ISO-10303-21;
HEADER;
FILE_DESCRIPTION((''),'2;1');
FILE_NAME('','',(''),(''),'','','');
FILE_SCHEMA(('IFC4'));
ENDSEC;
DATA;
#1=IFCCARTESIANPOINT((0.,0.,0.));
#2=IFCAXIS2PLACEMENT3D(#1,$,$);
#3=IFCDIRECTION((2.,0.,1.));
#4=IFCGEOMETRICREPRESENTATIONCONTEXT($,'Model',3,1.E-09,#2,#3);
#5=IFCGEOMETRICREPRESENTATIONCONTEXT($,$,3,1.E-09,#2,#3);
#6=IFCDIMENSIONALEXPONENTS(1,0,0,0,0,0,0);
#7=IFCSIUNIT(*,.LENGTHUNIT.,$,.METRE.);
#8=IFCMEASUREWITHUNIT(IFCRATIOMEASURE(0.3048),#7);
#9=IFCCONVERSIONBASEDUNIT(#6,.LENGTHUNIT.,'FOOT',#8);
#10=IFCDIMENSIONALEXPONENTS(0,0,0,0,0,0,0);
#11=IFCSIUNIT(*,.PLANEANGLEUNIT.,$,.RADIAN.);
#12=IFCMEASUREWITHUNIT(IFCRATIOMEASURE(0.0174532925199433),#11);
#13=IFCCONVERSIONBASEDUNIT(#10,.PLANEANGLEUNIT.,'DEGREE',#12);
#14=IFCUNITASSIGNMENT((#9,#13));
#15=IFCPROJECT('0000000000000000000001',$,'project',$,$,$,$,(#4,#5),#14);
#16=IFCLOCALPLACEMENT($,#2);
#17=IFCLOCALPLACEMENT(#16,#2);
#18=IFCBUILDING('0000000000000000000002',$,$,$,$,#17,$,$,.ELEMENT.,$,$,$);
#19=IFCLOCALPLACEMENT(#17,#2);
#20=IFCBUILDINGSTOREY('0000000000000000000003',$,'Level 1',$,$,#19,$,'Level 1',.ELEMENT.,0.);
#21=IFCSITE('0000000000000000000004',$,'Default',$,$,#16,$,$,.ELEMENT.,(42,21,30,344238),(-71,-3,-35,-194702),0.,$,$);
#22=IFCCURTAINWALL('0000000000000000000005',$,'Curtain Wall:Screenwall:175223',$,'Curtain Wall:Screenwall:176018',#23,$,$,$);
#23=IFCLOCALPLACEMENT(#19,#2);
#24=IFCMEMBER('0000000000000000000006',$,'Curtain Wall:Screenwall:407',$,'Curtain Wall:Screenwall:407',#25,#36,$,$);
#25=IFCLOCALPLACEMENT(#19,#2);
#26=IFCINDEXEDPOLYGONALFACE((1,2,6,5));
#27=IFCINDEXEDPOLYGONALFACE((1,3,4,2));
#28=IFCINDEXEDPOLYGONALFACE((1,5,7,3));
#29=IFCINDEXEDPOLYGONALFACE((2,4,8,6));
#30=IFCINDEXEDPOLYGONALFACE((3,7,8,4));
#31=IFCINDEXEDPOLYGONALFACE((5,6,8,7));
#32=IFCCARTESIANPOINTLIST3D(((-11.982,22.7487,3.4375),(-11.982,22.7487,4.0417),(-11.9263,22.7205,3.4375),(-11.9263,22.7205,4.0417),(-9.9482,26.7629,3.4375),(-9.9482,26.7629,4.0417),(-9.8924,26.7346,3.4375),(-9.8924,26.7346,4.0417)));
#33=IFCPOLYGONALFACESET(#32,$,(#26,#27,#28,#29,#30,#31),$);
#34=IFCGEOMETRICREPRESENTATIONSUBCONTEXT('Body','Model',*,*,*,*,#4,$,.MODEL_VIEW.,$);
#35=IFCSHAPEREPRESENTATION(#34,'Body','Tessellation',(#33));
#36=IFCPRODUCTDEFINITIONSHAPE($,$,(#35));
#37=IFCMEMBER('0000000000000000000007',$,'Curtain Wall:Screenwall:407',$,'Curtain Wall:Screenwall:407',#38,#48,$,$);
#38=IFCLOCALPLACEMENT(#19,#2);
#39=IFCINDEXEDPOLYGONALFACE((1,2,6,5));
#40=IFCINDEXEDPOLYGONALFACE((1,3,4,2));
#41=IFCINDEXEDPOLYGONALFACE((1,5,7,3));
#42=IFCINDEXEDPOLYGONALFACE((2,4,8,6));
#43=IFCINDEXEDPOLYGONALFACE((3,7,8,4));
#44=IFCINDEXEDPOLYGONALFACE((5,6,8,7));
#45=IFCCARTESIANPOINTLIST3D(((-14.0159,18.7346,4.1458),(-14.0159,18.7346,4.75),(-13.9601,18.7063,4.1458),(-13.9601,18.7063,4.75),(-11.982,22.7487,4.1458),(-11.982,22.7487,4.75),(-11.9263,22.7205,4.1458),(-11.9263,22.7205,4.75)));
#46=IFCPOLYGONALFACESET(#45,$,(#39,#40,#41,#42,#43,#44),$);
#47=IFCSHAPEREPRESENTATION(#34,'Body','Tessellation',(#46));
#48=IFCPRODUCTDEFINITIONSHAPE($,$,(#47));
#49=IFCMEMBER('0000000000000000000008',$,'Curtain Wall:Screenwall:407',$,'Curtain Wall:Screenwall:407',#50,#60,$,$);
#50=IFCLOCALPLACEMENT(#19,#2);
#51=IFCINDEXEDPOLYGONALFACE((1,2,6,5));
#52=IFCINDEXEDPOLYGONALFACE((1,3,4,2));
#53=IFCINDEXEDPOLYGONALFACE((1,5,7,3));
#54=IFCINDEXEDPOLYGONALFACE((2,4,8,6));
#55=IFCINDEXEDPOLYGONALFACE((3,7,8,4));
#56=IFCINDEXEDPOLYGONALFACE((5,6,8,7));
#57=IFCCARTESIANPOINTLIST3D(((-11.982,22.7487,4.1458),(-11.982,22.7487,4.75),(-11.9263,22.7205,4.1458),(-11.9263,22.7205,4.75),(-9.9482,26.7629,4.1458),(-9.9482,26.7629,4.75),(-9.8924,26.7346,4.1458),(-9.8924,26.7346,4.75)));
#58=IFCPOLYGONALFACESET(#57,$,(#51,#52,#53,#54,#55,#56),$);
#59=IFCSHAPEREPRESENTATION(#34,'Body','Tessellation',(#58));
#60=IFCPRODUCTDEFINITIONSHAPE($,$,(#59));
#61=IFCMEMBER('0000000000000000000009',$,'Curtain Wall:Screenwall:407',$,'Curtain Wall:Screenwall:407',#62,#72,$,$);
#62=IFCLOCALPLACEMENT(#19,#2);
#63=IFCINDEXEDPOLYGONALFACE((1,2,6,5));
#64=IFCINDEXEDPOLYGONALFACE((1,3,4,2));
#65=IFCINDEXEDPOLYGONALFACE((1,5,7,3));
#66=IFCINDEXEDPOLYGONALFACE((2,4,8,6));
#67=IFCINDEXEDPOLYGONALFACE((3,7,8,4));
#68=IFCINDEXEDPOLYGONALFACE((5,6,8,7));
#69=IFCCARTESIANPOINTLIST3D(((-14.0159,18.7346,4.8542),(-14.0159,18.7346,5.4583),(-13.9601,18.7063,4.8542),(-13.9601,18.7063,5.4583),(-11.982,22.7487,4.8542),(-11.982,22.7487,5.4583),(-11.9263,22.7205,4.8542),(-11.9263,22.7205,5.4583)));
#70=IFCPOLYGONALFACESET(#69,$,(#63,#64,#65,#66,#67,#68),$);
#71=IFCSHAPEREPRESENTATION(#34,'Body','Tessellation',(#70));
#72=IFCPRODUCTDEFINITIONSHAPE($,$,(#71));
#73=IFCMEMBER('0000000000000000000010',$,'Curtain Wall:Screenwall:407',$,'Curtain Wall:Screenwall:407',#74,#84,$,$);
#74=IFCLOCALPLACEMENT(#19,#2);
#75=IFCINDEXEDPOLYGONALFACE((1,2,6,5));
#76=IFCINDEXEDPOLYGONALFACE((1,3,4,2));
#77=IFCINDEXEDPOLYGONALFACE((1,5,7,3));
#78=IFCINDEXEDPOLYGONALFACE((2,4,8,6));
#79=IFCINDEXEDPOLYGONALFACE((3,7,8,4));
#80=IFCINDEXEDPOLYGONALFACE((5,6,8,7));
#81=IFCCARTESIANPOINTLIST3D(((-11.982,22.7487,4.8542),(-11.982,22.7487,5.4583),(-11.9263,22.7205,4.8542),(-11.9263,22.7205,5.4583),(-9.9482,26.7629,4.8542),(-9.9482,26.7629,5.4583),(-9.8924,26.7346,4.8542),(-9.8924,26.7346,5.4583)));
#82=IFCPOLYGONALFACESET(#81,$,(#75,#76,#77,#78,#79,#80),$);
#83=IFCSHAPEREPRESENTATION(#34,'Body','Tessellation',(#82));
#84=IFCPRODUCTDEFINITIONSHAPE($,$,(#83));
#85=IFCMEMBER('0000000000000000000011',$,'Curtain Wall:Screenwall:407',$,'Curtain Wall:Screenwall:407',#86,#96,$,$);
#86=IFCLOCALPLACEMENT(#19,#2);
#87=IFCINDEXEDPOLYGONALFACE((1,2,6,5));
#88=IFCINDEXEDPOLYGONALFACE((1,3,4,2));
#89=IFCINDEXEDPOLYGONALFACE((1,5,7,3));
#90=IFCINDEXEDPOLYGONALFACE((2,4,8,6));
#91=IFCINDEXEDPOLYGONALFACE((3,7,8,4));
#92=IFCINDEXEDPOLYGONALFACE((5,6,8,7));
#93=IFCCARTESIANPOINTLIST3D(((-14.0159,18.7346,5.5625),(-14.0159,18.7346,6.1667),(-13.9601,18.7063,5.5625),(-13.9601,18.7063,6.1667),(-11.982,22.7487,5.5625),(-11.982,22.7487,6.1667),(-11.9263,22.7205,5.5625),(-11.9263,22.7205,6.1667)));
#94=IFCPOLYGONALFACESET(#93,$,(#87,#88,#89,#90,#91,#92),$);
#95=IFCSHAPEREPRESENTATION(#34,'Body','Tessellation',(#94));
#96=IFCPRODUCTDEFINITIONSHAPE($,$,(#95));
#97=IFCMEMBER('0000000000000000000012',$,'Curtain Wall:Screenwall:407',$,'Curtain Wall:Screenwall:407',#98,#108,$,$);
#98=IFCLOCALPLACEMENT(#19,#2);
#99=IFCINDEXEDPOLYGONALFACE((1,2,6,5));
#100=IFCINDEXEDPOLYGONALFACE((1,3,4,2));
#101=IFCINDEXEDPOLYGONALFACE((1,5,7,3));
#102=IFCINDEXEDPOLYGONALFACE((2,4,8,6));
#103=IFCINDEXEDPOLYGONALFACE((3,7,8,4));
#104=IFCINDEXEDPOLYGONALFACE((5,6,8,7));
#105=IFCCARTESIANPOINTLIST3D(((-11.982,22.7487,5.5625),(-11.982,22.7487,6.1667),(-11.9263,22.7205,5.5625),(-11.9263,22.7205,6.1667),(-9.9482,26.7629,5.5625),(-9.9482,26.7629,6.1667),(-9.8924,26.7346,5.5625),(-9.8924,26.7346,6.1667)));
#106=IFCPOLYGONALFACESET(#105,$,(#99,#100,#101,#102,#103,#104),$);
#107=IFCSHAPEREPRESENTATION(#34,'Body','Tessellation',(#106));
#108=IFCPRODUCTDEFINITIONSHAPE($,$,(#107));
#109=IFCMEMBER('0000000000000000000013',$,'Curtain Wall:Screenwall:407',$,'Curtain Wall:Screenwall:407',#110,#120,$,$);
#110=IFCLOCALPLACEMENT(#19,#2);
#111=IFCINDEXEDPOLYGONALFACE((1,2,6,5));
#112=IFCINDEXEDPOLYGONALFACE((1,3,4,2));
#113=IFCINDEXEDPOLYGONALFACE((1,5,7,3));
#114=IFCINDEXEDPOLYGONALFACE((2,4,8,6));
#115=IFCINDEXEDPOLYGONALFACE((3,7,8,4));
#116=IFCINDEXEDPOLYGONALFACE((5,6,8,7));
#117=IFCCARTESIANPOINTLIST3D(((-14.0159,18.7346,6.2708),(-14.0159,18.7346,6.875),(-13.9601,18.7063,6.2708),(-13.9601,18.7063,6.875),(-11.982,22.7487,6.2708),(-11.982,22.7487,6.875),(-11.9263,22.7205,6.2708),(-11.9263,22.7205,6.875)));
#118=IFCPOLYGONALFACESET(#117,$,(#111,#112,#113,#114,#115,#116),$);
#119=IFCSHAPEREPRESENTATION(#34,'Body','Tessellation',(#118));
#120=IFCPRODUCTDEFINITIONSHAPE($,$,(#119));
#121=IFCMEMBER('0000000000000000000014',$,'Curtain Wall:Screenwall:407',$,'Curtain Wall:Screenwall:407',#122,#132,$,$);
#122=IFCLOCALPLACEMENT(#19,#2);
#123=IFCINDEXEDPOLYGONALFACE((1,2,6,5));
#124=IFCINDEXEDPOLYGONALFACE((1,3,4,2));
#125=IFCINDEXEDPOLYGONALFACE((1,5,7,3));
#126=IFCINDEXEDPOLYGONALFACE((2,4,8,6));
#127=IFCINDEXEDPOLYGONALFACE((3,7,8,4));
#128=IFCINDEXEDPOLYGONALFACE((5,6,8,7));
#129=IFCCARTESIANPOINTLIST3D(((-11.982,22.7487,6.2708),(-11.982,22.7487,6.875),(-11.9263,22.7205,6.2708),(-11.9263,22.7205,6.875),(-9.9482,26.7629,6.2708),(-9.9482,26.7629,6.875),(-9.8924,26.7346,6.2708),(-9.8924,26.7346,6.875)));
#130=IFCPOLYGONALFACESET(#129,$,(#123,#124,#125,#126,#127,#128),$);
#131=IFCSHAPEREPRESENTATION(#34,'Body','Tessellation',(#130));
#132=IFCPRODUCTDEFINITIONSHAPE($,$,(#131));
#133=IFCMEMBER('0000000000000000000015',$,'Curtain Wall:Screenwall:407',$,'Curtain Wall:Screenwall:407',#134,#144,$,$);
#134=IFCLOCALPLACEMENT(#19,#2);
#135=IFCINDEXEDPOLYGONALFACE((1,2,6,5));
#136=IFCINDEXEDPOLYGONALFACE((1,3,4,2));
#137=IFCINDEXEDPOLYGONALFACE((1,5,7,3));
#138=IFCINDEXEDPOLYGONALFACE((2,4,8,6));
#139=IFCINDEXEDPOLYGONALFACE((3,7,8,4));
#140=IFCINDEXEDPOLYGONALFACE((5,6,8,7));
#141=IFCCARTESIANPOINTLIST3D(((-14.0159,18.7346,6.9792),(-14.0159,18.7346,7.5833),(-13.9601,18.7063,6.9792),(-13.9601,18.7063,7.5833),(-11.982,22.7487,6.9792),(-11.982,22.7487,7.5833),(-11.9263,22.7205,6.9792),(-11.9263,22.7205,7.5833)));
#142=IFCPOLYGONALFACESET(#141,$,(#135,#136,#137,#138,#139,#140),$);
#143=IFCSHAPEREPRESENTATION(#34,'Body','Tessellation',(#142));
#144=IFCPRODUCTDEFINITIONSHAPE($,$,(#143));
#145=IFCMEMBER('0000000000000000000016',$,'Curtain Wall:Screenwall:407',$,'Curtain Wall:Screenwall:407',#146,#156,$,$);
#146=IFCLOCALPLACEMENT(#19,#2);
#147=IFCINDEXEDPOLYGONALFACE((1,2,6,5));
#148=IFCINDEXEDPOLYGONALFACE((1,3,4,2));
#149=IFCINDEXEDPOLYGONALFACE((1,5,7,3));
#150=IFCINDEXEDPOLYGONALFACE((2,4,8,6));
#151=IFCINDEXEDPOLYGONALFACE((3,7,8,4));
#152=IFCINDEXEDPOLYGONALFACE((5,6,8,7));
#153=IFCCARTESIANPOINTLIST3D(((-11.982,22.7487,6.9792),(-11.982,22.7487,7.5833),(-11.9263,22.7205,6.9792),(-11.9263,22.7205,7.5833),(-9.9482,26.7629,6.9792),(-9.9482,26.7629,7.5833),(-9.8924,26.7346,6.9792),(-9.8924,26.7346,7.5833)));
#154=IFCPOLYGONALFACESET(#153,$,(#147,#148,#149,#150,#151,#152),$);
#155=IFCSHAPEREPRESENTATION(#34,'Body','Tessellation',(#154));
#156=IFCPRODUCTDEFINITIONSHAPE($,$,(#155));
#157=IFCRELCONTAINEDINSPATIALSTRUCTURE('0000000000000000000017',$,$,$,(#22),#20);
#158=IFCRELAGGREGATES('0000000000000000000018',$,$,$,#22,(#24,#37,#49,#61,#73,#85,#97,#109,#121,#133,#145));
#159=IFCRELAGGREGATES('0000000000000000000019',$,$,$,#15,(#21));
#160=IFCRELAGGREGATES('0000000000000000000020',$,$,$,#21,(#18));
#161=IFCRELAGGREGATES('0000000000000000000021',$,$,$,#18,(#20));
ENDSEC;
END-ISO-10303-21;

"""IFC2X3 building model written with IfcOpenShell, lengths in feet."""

from ifc_helpers import new_model, entity, si_unit, converted_unit, direction, frame, frame_2d, origin, place, context, subcontext, project, spatial, rectangle, extrude, element, aggregate, save


model = new_model("IFC2X3")

# Units and contexts
model_context = context("Model", 3, precision=1e-09, world=origin(), true_north=direction((2.0, 0.0, 1.0)))
context_of_model = context(None, 3, precision=1e-09, world=origin(), true_north=direction((2.0, 0.0, 1.0)))
body_context = subcontext(model_context, "Body", "Model", "MODEL_VIEW")
ifc_project = project(units=[converted_unit("LENGTHUNIT", "FOOT", entity("IfcRatioMeasure", 0.3048), si_unit("LENGTHUNIT", "METRE"), dimensions=[1, 0, 0, 0, 0, 0, 0]), converted_unit("PLANEANGLEUNIT", "DEGREE", entity("IfcRatioMeasure", 0.0174532925199433), si_unit("PLANEANGLEUNIT", "RADIAN"), dimensions=[0, 0, 0, 0, 0, 0, 0])], contexts=[model_context, context_of_model])

# Site, building, storey
site_placement = place(None, origin())
site = spatial("IfcSite", under=ifc_project, at=site_placement, Name="Default", CompositionType="ELEMENT", RefLatitude=(42, 21, 30, 344238), RefLongitude=(-71, -3, -35, -194702), RefElevation=0.0)
building_placement = place(site_placement, origin())
building = spatial("IfcBuilding", under=site, at=building_placement, CompositionType="ELEMENT")
storey_placement = place(building_placement, origin())
storey = spatial("IfcBuildingStorey", under=building, at=storey_placement, Name="Level 1", LongName="Level 1", CompositionType="ELEMENT", Elevation=0.0)

# Curtain wall, members
curtain_wall_placement = place(storey_placement, origin())
curtain_wall = element("IfcCurtainWall", 1, at=curtain_wall_placement, inside=storey, Name="Curtain Wall:Screenwall:175223", ObjectType="Curtain Wall:Screenwall:176018")
member_1_placement = place(curtain_wall_placement, frame((-11.982, 22.7205, 3.4375)))
member_1 = element("IfcMember", 2, at=member_1_placement, Name="Curtain Wall:Screenwall:407", ObjectType="Curtain Wall:Screenwall:407", context=body_context, shape_type="SweptSolid", body=[
    extrude(rectangle(XDim=4.5, YDim=0.0625, at=frame_2d((0.0, 0.0), x_axis=(1.0, 0.0))), frame((1.0448, 2.0212, 0.0), z_axis=(0.0, 0.0, 1.0), x_axis=(-0.451968, -0.892034, 0.0)), (0.0, 0.0, 1.0), 0.6042),
])
member_2_placement = place(curtain_wall_placement, frame((-14.0159, 18.7063, 4.1458)))
member_2 = element("IfcMember", 3, at=member_2_placement, Name="Curtain Wall:Screenwall:407", ObjectType="Curtain Wall:Screenwall:407", context=body_context, shape_type="SweptSolid", body=[
    extrude(rectangle(XDim=4.5, YDim=0.0625, at=frame_2d((0.0, 0.0), x_axis=(1.0, 0.0))), frame((1.0448, 2.0212, 0.0), z_axis=(0.0, 0.0, 1.0), x_axis=(-0.451968, -0.892034, 0.0)), (0.0, 0.0, 1.0), 0.6042),
])
member_3_placement = place(curtain_wall_placement, frame((-11.982, 22.7205, 4.1458)))
member_3 = element("IfcMember", 4, at=member_3_placement, Name="Curtain Wall:Screenwall:407", ObjectType="Curtain Wall:Screenwall:407", context=body_context, shape_type="SweptSolid", body=[
    extrude(rectangle(XDim=4.5, YDim=0.0625, at=frame_2d((0.0, 0.0), x_axis=(1.0, 0.0))), frame((1.0448, 2.0212, 0.0), z_axis=(0.0, 0.0, 1.0), x_axis=(-0.451968, -0.892034, 0.0)), (0.0, 0.0, 1.0), 0.6042),
])
member_4_placement = place(curtain_wall_placement, frame((-14.0159, 18.7063, 4.8542)))
member_4 = element("IfcMember", 5, at=member_4_placement, Name="Curtain Wall:Screenwall:407", ObjectType="Curtain Wall:Screenwall:407", context=body_context, shape_type="SweptSolid", body=[
    extrude(rectangle(XDim=4.5, YDim=0.0625, at=frame_2d((0.0, 0.0), x_axis=(1.0, 0.0))), frame((1.0448, 2.0212, 0.0), z_axis=(0.0, 0.0, 1.0), x_axis=(-0.451968, -0.892034, 0.0)), (0.0, 0.0, 1.0), 0.6042),
])
member_5_placement = place(curtain_wall_placement, frame((-11.982, 22.7205, 4.8542)))
member_5 = element("IfcMember", 6, at=member_5_placement, Name="Curtain Wall:Screenwall:407", ObjectType="Curtain Wall:Screenwall:407", context=body_context, shape_type="SweptSolid", body=[
    extrude(rectangle(XDim=4.5, YDim=0.0625, at=frame_2d((0.0, 0.0), x_axis=(1.0, 0.0))), frame((1.0448, 2.0212, 0.0), z_axis=(0.0, 0.0, 1.0), x_axis=(-0.451968, -0.892034, 0.0)), (0.0, 0.0, 1.0), 0.6042),
])
member_6_placement = place(curtain_wall_placement, frame((-14.0159, 18.7063, 5.5625)))
member_6 = element("IfcMember", 7, at=member_6_placement, Name="Curtain Wall:Screenwall:407", ObjectType="Curtain Wall:Screenwall:407", context=body_context, shape_type="SweptSolid", body=[
    extrude(rectangle(XDim=4.5, YDim=0.0625, at=frame_2d((0.0, 0.0), x_axis=(1.0, 0.0))), frame((1.0448, 2.0212, 0.0), z_axis=(0.0, 0.0, 1.0), x_axis=(-0.451968, -0.892034, 0.0)), (0.0, 0.0, 1.0), 0.6042),
])
member_7_placement = place(curtain_wall_placement, frame((-11.982, 22.7205, 5.5625)))
member_7 = element("IfcMember", 8, at=member_7_placement, Name="Curtain Wall:Screenwall:407", ObjectType="Curtain Wall:Screenwall:407", context=body_context, shape_type="SweptSolid", body=[
    extrude(rectangle(XDim=4.5, YDim=0.0625, at=frame_2d((0.0, 0.0), x_axis=(1.0, 0.0))), frame((1.0448, 2.0212, 0.0), z_axis=(0.0, 0.0, 1.0), x_axis=(-0.451968, -0.892034, 0.0)), (0.0, 0.0, 1.0), 0.6042),
])
member_8_placement = place(curtain_wall_placement, frame((-14.0159, 18.7063, 6.2708)))
member_8 = element("IfcMember", 9, at=member_8_placement, Name="Curtain Wall:Screenwall:407", ObjectType="Curtain Wall:Screenwall:407", context=body_context, shape_type="SweptSolid", body=[
    extrude(rectangle(XDim=4.5, YDim=0.0625, at=frame_2d((0.0, 0.0), x_axis=(1.0, 0.0))), frame((1.0448, 2.0212, 0.0), z_axis=(0.0, 0.0, 1.0), x_axis=(-0.451968, -0.892034, 0.0)), (0.0, 0.0, 1.0), 0.6042),
])
member_9_placement = place(curtain_wall_placement, frame((-11.982, 22.7205, 6.2708)))
member_9 = element("IfcMember", 10, at=member_9_placement, Name="Curtain Wall:Screenwall:407", ObjectType="Curtain Wall:Screenwall:407", context=body_context, shape_type="SweptSolid", body=[
    extrude(rectangle(XDim=4.5, YDim=0.0625, at=frame_2d((0.0, 0.0), x_axis=(1.0, 0.0))), frame((1.0448, 2.0212, 0.0), z_axis=(0.0, 0.0, 1.0), x_axis=(-0.451968, -0.892034, 0.0)), (0.0, 0.0, 1.0), 0.6042),
])
member_10_placement = place(curtain_wall_placement, frame((-14.0159, 18.7063, 6.9792)))
member_10 = element("IfcMember", 11, at=member_10_placement, Name="Curtain Wall:Screenwall:407", ObjectType="Curtain Wall:Screenwall:407", context=body_context, shape_type="SweptSolid", body=[
    extrude(rectangle(XDim=4.5, YDim=0.0625, at=frame_2d((0.0, 0.0), x_axis=(1.0, 0.0))), frame((1.0448, 2.0212, 0.0), z_axis=(0.0, 0.0, 1.0), x_axis=(-0.451968, -0.892034, 0.0)), (0.0, 0.0, 1.0), 0.6042),
])
member_11_placement = place(curtain_wall_placement, frame((-11.982, 22.7205, 6.9792)))
member_11 = element("IfcMember", 12, at=member_11_placement, Name="Curtain Wall:Screenwall:407", ObjectType="Curtain Wall:Screenwall:407", context=body_context, shape_type="SweptSolid", body=[
    extrude(rectangle(XDim=4.5, YDim=0.0625, at=frame_2d((0.0, 0.0), x_axis=(1.0, 0.0))), frame((1.0448, 2.0212, 0.0), z_axis=(0.0, 0.0, 1.0), x_axis=(-0.451968, -0.892034, 0.0)), (0.0, 0.0, 1.0), 0.6042),
])
aggregate(curtain_wall, [member_1, member_2, member_3, member_4, member_5, member_6, member_7, member_8, member_9, member_10, member_11])

save(model, "model.ifc")
